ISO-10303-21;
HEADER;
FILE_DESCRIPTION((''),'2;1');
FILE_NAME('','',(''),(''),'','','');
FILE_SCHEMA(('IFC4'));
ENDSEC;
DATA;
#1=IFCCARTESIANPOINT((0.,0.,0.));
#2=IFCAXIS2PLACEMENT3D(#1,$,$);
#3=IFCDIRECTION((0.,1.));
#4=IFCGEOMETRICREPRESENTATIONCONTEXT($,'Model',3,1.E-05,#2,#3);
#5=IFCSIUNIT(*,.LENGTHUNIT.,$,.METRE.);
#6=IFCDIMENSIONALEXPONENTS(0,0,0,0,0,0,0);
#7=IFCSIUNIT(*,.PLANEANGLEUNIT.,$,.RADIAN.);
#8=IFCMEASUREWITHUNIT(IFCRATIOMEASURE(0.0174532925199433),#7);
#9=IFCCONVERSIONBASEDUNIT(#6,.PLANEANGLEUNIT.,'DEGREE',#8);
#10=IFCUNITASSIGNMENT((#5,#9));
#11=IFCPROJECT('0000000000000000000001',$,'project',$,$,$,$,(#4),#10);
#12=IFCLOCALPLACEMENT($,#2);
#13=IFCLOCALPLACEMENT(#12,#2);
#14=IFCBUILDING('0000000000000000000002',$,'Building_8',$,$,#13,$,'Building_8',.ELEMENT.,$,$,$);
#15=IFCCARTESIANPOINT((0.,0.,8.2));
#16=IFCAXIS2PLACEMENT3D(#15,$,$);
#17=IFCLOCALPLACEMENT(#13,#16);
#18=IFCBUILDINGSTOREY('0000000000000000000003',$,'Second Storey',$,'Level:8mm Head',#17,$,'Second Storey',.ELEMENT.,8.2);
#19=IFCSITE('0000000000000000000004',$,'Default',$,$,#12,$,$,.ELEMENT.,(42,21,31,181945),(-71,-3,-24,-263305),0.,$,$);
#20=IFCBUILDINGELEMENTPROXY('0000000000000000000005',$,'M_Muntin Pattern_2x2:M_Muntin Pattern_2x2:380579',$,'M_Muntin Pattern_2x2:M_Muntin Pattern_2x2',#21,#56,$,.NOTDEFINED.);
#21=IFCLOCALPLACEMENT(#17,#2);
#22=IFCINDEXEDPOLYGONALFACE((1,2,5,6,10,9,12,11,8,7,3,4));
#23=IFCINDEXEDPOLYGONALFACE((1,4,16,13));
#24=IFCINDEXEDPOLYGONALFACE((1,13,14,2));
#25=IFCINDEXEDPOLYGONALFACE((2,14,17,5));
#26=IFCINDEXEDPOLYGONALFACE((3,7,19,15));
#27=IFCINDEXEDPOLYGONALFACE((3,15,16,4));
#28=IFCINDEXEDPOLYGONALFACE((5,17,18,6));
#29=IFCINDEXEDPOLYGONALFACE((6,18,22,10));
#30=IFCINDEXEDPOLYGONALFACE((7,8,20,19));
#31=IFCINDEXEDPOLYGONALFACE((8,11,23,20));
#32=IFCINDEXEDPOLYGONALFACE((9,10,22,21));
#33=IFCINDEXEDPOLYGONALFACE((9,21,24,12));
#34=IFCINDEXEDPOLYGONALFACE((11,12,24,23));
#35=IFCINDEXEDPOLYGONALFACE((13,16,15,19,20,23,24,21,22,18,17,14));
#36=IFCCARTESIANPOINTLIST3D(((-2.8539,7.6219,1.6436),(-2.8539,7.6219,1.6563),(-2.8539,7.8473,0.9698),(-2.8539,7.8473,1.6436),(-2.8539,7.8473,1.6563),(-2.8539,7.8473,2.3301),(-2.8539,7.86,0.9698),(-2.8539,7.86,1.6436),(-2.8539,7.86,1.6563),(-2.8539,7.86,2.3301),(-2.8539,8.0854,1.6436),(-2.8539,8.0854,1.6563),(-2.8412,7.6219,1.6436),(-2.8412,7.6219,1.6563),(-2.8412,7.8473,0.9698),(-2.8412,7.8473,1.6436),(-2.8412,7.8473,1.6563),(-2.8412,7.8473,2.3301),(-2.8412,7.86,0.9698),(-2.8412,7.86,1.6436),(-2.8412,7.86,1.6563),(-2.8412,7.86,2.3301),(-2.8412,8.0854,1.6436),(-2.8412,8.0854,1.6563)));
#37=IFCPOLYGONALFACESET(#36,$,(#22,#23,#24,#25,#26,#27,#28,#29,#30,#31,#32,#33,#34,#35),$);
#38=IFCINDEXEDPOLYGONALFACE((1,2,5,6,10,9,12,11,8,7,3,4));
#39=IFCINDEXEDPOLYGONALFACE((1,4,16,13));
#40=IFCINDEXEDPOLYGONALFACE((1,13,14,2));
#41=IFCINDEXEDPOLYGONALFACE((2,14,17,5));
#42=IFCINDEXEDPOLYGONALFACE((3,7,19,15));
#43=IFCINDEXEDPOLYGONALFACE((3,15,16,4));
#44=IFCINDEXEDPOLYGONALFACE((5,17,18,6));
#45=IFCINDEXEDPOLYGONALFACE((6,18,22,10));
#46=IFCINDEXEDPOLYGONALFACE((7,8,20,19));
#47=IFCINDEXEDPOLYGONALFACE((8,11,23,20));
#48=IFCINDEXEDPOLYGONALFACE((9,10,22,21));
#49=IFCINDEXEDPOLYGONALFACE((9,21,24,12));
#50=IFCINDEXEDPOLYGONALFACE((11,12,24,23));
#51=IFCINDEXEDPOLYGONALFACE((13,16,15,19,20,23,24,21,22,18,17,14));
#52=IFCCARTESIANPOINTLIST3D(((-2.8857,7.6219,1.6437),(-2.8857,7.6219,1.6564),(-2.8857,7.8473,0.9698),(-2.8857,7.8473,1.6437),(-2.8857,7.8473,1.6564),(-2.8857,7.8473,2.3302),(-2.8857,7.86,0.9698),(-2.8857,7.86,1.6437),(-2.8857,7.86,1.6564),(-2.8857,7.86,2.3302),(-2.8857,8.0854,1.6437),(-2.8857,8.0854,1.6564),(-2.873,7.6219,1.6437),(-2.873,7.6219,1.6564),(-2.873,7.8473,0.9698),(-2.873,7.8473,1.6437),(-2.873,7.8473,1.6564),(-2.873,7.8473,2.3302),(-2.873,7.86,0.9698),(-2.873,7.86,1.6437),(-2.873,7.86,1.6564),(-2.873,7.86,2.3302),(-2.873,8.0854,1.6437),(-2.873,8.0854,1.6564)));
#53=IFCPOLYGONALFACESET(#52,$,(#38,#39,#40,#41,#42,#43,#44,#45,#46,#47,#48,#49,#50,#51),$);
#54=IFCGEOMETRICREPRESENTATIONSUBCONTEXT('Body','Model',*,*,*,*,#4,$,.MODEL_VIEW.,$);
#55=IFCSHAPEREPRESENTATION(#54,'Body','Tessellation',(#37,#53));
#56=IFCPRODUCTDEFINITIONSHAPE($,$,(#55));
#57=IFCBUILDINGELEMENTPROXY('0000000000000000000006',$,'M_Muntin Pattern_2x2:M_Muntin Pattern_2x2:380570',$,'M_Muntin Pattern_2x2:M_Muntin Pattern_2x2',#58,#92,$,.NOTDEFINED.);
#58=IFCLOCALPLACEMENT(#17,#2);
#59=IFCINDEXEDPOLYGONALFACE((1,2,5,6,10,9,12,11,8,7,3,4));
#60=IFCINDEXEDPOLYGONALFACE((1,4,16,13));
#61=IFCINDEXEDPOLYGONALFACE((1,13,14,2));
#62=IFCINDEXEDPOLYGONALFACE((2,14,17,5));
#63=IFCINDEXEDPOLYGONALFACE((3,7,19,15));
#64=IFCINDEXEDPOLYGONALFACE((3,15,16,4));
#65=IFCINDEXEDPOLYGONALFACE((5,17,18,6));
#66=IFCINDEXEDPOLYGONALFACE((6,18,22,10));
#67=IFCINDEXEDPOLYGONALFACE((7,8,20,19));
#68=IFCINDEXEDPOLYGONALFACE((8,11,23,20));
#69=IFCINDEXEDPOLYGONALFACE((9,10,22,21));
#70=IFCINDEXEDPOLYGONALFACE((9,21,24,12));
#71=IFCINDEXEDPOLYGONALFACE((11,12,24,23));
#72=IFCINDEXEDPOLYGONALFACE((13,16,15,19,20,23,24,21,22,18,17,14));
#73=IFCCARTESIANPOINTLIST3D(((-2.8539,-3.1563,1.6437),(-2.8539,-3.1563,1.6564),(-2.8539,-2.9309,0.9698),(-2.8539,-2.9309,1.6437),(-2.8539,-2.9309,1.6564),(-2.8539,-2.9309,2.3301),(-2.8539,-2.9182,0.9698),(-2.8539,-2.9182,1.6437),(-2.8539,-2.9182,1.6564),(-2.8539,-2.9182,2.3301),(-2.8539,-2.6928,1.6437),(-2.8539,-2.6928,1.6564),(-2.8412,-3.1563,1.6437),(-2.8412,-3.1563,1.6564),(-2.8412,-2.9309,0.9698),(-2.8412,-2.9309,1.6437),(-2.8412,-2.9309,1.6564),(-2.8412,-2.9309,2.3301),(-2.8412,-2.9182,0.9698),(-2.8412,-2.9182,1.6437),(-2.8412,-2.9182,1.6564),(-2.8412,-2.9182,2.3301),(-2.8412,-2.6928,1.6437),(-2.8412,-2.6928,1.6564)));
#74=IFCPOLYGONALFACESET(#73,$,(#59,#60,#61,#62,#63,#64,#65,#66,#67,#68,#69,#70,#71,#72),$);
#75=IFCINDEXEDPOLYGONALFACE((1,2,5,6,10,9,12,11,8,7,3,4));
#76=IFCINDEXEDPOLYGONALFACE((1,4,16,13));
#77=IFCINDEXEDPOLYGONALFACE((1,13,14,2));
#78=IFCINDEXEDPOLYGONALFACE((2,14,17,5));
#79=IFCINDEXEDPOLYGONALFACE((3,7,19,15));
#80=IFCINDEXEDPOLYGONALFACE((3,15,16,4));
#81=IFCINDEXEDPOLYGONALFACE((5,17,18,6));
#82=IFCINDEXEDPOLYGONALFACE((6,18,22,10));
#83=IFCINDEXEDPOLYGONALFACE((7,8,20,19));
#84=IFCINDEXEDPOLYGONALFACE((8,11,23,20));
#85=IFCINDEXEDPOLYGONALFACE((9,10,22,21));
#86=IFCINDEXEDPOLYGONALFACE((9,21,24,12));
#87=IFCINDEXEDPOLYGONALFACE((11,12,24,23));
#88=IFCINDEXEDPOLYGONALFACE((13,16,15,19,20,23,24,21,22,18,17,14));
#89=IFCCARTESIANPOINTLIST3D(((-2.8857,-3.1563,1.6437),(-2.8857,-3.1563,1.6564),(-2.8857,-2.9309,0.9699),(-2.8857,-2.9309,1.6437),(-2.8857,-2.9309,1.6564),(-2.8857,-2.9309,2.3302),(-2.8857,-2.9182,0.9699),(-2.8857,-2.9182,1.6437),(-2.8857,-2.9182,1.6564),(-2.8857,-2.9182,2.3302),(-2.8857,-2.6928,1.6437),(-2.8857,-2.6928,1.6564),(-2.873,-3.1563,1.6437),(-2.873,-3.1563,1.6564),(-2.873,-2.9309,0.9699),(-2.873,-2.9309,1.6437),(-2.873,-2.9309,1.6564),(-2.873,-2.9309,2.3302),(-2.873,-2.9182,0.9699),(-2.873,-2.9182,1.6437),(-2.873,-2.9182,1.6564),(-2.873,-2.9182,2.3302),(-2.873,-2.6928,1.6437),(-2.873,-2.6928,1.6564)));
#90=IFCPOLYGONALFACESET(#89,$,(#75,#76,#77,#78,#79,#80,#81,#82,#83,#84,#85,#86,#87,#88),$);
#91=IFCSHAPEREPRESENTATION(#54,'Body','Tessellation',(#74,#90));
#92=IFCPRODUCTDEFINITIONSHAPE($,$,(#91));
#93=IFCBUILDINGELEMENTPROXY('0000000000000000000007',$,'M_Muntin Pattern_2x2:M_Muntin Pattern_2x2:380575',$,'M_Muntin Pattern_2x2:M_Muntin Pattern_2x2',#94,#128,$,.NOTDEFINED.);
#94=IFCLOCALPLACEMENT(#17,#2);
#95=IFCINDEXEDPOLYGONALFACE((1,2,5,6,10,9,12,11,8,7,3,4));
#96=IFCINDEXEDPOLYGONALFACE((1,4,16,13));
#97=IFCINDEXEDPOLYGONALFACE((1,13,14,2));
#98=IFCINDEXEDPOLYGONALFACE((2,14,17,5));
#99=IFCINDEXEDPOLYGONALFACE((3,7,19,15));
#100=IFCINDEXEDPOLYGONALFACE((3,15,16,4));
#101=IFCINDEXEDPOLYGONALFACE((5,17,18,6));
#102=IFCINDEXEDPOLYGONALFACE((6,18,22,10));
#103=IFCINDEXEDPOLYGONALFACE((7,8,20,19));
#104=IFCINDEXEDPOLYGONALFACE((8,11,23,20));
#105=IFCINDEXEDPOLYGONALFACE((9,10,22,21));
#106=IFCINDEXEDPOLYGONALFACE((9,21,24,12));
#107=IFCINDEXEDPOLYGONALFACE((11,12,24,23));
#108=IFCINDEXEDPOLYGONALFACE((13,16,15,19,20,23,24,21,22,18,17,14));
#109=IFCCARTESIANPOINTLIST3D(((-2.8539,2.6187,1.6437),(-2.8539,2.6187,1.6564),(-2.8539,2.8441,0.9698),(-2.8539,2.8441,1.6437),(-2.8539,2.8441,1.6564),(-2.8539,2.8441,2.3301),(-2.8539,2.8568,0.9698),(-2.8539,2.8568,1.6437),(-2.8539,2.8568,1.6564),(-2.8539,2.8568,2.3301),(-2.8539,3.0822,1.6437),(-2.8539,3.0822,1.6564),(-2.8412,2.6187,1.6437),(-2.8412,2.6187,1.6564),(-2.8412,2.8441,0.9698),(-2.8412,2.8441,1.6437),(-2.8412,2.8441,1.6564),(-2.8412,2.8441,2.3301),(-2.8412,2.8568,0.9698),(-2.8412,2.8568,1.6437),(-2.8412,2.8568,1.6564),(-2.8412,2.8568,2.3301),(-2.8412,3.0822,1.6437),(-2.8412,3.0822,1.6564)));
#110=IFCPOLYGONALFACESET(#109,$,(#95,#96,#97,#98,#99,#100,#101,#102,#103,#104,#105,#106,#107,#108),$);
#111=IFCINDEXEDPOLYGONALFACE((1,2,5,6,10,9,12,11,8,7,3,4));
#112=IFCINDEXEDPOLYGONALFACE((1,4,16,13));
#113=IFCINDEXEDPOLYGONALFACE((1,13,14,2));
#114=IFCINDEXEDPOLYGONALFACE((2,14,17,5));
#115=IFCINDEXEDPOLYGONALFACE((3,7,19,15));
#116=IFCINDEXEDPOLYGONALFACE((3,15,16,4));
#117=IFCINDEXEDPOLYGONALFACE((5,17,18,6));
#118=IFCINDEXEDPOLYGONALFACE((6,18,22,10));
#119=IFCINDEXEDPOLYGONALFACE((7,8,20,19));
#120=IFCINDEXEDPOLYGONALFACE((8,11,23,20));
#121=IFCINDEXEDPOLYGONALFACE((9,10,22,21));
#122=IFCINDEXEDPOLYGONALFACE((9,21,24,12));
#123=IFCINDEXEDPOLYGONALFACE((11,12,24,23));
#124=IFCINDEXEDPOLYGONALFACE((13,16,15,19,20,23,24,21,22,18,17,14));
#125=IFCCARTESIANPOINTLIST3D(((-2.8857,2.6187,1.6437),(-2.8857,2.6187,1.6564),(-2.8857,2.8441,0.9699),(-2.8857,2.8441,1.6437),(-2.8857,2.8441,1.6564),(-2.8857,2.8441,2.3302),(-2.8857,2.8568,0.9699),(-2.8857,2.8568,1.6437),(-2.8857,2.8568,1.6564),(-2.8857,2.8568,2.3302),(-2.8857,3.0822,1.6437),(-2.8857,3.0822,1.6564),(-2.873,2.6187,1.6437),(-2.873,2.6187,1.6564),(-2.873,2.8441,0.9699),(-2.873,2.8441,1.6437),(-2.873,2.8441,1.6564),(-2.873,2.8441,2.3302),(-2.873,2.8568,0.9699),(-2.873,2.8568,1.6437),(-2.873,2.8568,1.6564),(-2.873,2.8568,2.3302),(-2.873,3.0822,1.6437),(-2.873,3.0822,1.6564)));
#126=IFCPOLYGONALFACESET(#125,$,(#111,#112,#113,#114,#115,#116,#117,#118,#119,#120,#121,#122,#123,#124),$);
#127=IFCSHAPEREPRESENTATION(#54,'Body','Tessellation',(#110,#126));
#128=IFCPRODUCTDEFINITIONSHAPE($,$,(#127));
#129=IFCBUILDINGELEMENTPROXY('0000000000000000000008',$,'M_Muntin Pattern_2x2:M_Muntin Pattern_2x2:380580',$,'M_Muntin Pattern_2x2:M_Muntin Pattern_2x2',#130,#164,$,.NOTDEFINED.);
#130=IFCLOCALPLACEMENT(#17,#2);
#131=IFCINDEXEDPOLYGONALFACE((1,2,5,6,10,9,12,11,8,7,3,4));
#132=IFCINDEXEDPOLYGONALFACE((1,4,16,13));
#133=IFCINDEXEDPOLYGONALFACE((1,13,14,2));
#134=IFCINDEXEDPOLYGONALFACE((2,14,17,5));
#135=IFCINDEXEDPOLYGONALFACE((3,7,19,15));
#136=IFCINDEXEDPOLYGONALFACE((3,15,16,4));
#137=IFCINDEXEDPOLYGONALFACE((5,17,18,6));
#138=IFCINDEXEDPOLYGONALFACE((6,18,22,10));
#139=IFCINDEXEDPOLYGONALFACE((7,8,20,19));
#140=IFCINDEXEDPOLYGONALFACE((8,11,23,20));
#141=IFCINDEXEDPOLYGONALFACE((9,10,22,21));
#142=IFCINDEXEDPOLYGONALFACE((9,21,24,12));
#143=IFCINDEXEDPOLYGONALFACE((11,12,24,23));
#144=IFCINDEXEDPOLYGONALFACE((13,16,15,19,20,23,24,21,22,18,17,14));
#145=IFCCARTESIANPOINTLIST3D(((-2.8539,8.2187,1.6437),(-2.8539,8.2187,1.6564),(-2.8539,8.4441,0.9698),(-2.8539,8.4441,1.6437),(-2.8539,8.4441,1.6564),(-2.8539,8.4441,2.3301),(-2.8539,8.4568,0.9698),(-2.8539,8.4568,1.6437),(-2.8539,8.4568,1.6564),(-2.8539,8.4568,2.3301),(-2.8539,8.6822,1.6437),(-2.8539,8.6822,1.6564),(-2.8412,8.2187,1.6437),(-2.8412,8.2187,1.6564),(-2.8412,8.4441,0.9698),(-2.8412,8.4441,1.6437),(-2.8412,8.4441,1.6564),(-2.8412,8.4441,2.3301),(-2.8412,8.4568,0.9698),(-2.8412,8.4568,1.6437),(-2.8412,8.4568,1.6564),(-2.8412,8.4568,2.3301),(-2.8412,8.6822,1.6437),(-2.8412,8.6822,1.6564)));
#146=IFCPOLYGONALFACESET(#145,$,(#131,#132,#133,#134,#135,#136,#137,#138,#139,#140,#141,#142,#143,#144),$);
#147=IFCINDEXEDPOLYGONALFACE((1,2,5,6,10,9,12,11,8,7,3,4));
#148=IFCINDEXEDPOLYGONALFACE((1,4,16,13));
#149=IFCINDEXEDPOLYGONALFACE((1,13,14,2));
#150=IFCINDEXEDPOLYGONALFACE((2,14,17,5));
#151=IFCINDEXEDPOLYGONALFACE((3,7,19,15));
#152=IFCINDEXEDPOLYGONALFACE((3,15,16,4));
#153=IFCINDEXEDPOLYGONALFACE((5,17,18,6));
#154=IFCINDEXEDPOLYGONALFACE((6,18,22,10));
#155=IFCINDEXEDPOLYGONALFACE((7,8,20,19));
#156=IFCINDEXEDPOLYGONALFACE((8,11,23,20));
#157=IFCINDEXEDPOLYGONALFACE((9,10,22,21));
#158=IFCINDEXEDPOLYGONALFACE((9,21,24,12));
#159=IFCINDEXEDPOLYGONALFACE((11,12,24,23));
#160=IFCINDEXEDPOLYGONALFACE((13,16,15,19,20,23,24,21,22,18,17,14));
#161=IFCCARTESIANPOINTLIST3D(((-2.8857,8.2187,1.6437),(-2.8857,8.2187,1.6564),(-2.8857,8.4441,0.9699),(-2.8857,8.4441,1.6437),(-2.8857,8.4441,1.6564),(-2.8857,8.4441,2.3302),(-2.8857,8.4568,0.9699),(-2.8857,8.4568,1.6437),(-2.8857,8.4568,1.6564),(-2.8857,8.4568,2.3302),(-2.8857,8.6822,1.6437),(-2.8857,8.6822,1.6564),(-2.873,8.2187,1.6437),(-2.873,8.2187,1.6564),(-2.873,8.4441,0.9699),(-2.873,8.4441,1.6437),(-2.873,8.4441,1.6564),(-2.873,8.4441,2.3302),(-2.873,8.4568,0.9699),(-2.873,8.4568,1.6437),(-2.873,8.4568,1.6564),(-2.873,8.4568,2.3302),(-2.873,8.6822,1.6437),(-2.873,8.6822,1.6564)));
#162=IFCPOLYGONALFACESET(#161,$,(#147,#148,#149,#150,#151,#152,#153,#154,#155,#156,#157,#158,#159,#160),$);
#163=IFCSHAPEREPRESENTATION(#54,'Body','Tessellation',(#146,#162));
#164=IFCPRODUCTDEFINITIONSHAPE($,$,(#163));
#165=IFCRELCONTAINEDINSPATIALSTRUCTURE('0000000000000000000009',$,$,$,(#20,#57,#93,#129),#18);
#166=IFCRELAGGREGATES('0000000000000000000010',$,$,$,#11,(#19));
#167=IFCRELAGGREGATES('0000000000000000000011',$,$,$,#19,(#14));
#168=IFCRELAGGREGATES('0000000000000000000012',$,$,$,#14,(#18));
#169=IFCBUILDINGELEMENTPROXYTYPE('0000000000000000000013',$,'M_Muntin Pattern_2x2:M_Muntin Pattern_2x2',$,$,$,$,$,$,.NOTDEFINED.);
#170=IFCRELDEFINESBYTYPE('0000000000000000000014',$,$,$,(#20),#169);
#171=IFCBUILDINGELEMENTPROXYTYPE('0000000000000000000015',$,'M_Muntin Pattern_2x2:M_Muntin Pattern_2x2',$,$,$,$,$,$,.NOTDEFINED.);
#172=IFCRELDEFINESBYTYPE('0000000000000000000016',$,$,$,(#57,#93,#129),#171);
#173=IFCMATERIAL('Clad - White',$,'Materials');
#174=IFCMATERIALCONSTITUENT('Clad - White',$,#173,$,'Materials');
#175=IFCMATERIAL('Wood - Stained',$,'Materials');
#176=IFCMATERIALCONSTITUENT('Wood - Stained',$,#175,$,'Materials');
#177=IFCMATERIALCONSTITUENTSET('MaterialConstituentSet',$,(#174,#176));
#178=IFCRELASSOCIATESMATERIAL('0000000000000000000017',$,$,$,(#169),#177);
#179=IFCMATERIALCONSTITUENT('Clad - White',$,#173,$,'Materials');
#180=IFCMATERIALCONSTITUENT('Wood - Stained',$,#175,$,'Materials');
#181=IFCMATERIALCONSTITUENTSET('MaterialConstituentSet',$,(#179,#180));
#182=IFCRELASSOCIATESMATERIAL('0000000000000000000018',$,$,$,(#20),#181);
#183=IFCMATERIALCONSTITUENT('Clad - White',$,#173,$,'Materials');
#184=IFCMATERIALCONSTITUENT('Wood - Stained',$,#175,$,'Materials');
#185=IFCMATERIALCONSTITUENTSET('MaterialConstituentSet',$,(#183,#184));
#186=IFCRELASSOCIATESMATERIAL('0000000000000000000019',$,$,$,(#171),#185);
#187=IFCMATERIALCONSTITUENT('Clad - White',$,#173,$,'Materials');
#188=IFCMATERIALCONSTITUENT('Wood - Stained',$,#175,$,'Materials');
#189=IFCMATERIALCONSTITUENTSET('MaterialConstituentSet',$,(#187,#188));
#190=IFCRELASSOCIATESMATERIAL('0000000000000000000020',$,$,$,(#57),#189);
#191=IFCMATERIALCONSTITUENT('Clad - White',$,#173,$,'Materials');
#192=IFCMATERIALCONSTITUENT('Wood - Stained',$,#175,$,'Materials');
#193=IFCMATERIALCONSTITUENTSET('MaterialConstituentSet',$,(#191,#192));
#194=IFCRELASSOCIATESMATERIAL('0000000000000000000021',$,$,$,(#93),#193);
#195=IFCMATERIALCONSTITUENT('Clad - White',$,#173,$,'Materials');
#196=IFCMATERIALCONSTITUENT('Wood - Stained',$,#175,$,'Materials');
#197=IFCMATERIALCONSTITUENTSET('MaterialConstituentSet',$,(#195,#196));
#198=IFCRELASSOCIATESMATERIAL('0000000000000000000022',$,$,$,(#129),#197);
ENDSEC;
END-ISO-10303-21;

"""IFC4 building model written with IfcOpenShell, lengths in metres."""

from ifc_helpers import new_model, entity, si_unit, converted_unit, direction, frame, origin, place, context, subcontext, project, spatial, indexed_curve, outline, extrude, source, transform, mapped, material, constituent, constituent_set, type_object, type_shapes, element, save


model = new_model("IFC4")

# Units and contexts
model_context = context("Model", 3, precision=1e-05, world=origin(), true_north=direction((0.0, 1.0)))
body_context = subcontext(model_context, "Body", "Model", "MODEL_VIEW")
ifc_project = project(units=[si_unit("LENGTHUNIT", "METRE"), converted_unit("PLANEANGLEUNIT", "DEGREE", entity("IfcRatioMeasure", 0.0174532925199433), si_unit("PLANEANGLEUNIT", "RADIAN"), dimensions=[0, 0, 0, 0, 0, 0, 0])], contexts=[model_context])

# Site, building, storey
site_placement = place(None, origin())
site = spatial("IfcSite", under=ifc_project, at=site_placement, Name="Default", CompositionType="ELEMENT", RefLatitude=(42, 21, 31, 181945), RefLongitude=(-71, -3, -24, -263305), RefElevation=0.0)
building_placement = place(site_placement, origin())
building = spatial("IfcBuilding", under=site, at=building_placement, Name="Building_8", LongName="Building_8", CompositionType="ELEMENT")
storey_placement = place(building_placement, frame((0.0, 0.0, 8.2)))
storey = spatial("IfcBuildingStorey", under=building, at=storey_placement, Name="Second Storey", ObjectType="Level:8mm Head", LongName="Second Storey", CompositionType="ELEMENT", Elevation=8.2)

# Shared definitions
ifc_material_1 = material(Name="Clad - White", Category="Materials")
ifc_material_2 = material(Name="Wood - Stained", Category="Materials")

# Building element proxies
ifc_constituent_1 = constituent(ifc_material_1, Name="Clad - White", Category="Materials")
ifc_constituent_2 = constituent(ifc_material_2, Name="Wood - Stained", Category="Materials")
ifc_constituent_set_1 = constituent_set(constituents=[ifc_constituent_1, ifc_constituent_2], Name="MaterialConstituentSet")
building_element_proxy_type_1 = type_object("IfcBuildingElementProxyType", Name="M_Muntin Pattern_2x2:M_Muntin Pattern_2x2", PredefinedType="NOTDEFINED", material=ifc_constituent_set_1)
shared_shape_1 = source(origin(), body_context, "Body", "SweptSolid", [
    extrude(outline(indexed_curve([(0.0064, -0.0064), (0.6801, -0.0064), (0.6801, 0.0063), (0.0064, 0.0063), (0.0064, 0.2317), (-0.0063, 0.2317), (-0.0063, 0.0063), (-0.6802, 0.0063), (-0.6802, -0.0064), (-0.0063, -0.0064), (-0.0063, -0.2317), (0.0064, -0.2317), (0.0064, -0.0064)], self_intersect=False)), frame((0.0, -0.0222, 0.6801), z_axis=(0.0, 1.0, 0.0), x_axis=(0.0, 0.0, 1.0)), (0.0, 0.0, 1.0), 0.0127),
    extrude(outline(indexed_curve([(0.0064, -0.0064), (0.6802, -0.0064), (0.6802, 0.0063), (0.0064, 0.0063), (0.0064, 0.2317), (-0.0063, 0.2317), (-0.0063, 0.0063), (-0.6802, 0.0063), (-0.6802, -0.0064), (-0.0063, -0.0064), (-0.0063, -0.2317), (0.0064, -0.2317), (0.0064, -0.0064)], self_intersect=False)), frame((0.0, 0.0095, 0.6802), z_axis=(0.0, 1.0, 0.0), x_axis=(0.0, 0.0, 1.0)), (0.0, 0.0, 1.0), 0.0127),
])
type_shapes(building_element_proxy_type_1, [shared_shape_1])
ifc_constituent_3 = constituent(ifc_material_1, Name="Clad - White", Category="Materials")
ifc_constituent_4 = constituent(ifc_material_2, Name="Wood - Stained", Category="Materials")
ifc_constituent_set_2 = constituent_set(constituents=[ifc_constituent_3, ifc_constituent_4], Name="MaterialConstituentSet")
proxy_1_placement = place(storey_placement, frame((-2.8634, 7.8537, 0.9698), z_axis=(0.0, 0.0, 1.0), x_axis=(0.0, 1.0, 0.0)))
element("IfcBuildingElementProxy", 1, at=proxy_1_placement, inside=storey, type_object=building_element_proxy_type_1, material=ifc_constituent_set_2, Name="M_Muntin Pattern_2x2:M_Muntin Pattern_2x2:380579", ObjectType="M_Muntin Pattern_2x2:M_Muntin Pattern_2x2", PredefinedType="NOTDEFINED", context=body_context, shape_type="MappedRepresentation", body=[
    mapped(shared_shape_1, transform((0.0, 0.0, 0.0), scale=1.0)),
])
ifc_constituent_5 = constituent(ifc_material_1, Name="Clad - White", Category="Materials")
ifc_constituent_6 = constituent(ifc_material_2, Name="Wood - Stained", Category="Materials")
ifc_constituent_set_3 = constituent_set(constituents=[ifc_constituent_5, ifc_constituent_6], Name="MaterialConstituentSet")
ifc_constituent_7 = constituent(ifc_material_1, Name="Clad - White", Category="Materials")
ifc_constituent_8 = constituent(ifc_material_2, Name="Wood - Stained", Category="Materials")
ifc_constituent_set_4 = constituent_set(constituents=[ifc_constituent_7, ifc_constituent_8], Name="MaterialConstituentSet")
building_element_proxy_type_2 = type_object("IfcBuildingElementProxyType", Name="M_Muntin Pattern_2x2:M_Muntin Pattern_2x2", PredefinedType="NOTDEFINED", material=ifc_constituent_set_4)
shared_shape_2 = source(origin(), body_context, "Body", "SweptSolid", [
    extrude(outline(indexed_curve([(0.0064, -0.0064), (0.6801, -0.0064), (0.6801, 0.0063), (0.0064, 0.0063), (0.0064, 0.2317), (-0.0063, 0.2317), (-0.0063, 0.0063), (-0.6802, 0.0063), (-0.6802, -0.0064), (-0.0063, -0.0064), (-0.0063, -0.2317), (0.0064, -0.2317), (0.0064, -0.0064)], self_intersect=False)), frame((0.0, 0.0095, 0.6801), z_axis=(0.0, 1.0, 0.0), x_axis=(0.0, 0.0, 1.0)), (0.0, 0.0, 1.0), 0.0127),
    extrude(outline(indexed_curve([(0.0064, -0.0064), (0.6802, -0.0064), (0.6802, 0.0063), (0.0064, 0.0063), (0.0064, 0.2317), (-0.0063, 0.2317), (-0.0063, 0.0063), (-0.6802, 0.0063), (-0.6802, -0.0064), (-0.0063, -0.0064), (-0.0063, -0.2317), (0.0064, -0.2317), (0.0064, -0.0064)], self_intersect=False)), frame((0.0, -0.0222, 0.6802), z_axis=(0.0, 1.0, 0.0), x_axis=(0.0, 0.0, 1.0)), (0.0, 0.0, 1.0), 0.0127),
])
type_shapes(building_element_proxy_type_2, [shared_shape_2])
proxy_2_placement = place(storey_placement, frame((-2.8634, -2.9245, 0.9699), z_axis=(0.0, 0.0, 1.0), x_axis=(0.0, -1.0, 0.0)))
element("IfcBuildingElementProxy", 2, at=proxy_2_placement, inside=storey, type_object=building_element_proxy_type_2, material=ifc_constituent_set_3, Name="M_Muntin Pattern_2x2:M_Muntin Pattern_2x2:380570", ObjectType="M_Muntin Pattern_2x2:M_Muntin Pattern_2x2", PredefinedType="NOTDEFINED", context=body_context, shape_type="MappedRepresentation", body=[
    mapped(shared_shape_2, transform((0.0, 0.0, 0.0), scale=1.0)),
])
ifc_constituent_9 = constituent(ifc_material_1, Name="Clad - White", Category="Materials")
ifc_constituent_10 = constituent(ifc_material_2, Name="Wood - Stained", Category="Materials")
ifc_constituent_set_5 = constituent_set(constituents=[ifc_constituent_9, ifc_constituent_10], Name="MaterialConstituentSet")
proxy_3_placement = place(storey_placement, frame((-2.8634, 2.8505, 0.9699), z_axis=(0.0, 0.0, 1.0), x_axis=(0.0, -1.0, 0.0)))
element("IfcBuildingElementProxy", 3, at=proxy_3_placement, inside=storey, type_object=building_element_proxy_type_2, material=ifc_constituent_set_5, Name="M_Muntin Pattern_2x2:M_Muntin Pattern_2x2:380575", ObjectType="M_Muntin Pattern_2x2:M_Muntin Pattern_2x2", PredefinedType="NOTDEFINED", context=body_context, shape_type="MappedRepresentation", body=[
    mapped(shared_shape_2, transform((0.0, 0.0, 0.0), scale=1.0)),
])
ifc_constituent_11 = constituent(ifc_material_1, Name="Clad - White", Category="Materials")
ifc_constituent_12 = constituent(ifc_material_2, Name="Wood - Stained", Category="Materials")
ifc_constituent_set_6 = constituent_set(constituents=[ifc_constituent_11, ifc_constituent_12], Name="MaterialConstituentSet")
proxy_4_placement = place(storey_placement, frame((-2.8634, 8.4505, 0.9699), z_axis=(0.0, 0.0, 1.0), x_axis=(0.0, -1.0, 0.0)))
element("IfcBuildingElementProxy", 4, at=proxy_4_placement, inside=storey, type_object=building_element_proxy_type_2, material=ifc_constituent_set_6, Name="M_Muntin Pattern_2x2:M_Muntin Pattern_2x2:380580", ObjectType="M_Muntin Pattern_2x2:M_Muntin Pattern_2x2", PredefinedType="NOTDEFINED", context=body_context, shape_type="MappedRepresentation", body=[
    mapped(shared_shape_2, transform((0.0, 0.0, 0.0), scale=1.0)),
])

save(model, "model.ifc")
